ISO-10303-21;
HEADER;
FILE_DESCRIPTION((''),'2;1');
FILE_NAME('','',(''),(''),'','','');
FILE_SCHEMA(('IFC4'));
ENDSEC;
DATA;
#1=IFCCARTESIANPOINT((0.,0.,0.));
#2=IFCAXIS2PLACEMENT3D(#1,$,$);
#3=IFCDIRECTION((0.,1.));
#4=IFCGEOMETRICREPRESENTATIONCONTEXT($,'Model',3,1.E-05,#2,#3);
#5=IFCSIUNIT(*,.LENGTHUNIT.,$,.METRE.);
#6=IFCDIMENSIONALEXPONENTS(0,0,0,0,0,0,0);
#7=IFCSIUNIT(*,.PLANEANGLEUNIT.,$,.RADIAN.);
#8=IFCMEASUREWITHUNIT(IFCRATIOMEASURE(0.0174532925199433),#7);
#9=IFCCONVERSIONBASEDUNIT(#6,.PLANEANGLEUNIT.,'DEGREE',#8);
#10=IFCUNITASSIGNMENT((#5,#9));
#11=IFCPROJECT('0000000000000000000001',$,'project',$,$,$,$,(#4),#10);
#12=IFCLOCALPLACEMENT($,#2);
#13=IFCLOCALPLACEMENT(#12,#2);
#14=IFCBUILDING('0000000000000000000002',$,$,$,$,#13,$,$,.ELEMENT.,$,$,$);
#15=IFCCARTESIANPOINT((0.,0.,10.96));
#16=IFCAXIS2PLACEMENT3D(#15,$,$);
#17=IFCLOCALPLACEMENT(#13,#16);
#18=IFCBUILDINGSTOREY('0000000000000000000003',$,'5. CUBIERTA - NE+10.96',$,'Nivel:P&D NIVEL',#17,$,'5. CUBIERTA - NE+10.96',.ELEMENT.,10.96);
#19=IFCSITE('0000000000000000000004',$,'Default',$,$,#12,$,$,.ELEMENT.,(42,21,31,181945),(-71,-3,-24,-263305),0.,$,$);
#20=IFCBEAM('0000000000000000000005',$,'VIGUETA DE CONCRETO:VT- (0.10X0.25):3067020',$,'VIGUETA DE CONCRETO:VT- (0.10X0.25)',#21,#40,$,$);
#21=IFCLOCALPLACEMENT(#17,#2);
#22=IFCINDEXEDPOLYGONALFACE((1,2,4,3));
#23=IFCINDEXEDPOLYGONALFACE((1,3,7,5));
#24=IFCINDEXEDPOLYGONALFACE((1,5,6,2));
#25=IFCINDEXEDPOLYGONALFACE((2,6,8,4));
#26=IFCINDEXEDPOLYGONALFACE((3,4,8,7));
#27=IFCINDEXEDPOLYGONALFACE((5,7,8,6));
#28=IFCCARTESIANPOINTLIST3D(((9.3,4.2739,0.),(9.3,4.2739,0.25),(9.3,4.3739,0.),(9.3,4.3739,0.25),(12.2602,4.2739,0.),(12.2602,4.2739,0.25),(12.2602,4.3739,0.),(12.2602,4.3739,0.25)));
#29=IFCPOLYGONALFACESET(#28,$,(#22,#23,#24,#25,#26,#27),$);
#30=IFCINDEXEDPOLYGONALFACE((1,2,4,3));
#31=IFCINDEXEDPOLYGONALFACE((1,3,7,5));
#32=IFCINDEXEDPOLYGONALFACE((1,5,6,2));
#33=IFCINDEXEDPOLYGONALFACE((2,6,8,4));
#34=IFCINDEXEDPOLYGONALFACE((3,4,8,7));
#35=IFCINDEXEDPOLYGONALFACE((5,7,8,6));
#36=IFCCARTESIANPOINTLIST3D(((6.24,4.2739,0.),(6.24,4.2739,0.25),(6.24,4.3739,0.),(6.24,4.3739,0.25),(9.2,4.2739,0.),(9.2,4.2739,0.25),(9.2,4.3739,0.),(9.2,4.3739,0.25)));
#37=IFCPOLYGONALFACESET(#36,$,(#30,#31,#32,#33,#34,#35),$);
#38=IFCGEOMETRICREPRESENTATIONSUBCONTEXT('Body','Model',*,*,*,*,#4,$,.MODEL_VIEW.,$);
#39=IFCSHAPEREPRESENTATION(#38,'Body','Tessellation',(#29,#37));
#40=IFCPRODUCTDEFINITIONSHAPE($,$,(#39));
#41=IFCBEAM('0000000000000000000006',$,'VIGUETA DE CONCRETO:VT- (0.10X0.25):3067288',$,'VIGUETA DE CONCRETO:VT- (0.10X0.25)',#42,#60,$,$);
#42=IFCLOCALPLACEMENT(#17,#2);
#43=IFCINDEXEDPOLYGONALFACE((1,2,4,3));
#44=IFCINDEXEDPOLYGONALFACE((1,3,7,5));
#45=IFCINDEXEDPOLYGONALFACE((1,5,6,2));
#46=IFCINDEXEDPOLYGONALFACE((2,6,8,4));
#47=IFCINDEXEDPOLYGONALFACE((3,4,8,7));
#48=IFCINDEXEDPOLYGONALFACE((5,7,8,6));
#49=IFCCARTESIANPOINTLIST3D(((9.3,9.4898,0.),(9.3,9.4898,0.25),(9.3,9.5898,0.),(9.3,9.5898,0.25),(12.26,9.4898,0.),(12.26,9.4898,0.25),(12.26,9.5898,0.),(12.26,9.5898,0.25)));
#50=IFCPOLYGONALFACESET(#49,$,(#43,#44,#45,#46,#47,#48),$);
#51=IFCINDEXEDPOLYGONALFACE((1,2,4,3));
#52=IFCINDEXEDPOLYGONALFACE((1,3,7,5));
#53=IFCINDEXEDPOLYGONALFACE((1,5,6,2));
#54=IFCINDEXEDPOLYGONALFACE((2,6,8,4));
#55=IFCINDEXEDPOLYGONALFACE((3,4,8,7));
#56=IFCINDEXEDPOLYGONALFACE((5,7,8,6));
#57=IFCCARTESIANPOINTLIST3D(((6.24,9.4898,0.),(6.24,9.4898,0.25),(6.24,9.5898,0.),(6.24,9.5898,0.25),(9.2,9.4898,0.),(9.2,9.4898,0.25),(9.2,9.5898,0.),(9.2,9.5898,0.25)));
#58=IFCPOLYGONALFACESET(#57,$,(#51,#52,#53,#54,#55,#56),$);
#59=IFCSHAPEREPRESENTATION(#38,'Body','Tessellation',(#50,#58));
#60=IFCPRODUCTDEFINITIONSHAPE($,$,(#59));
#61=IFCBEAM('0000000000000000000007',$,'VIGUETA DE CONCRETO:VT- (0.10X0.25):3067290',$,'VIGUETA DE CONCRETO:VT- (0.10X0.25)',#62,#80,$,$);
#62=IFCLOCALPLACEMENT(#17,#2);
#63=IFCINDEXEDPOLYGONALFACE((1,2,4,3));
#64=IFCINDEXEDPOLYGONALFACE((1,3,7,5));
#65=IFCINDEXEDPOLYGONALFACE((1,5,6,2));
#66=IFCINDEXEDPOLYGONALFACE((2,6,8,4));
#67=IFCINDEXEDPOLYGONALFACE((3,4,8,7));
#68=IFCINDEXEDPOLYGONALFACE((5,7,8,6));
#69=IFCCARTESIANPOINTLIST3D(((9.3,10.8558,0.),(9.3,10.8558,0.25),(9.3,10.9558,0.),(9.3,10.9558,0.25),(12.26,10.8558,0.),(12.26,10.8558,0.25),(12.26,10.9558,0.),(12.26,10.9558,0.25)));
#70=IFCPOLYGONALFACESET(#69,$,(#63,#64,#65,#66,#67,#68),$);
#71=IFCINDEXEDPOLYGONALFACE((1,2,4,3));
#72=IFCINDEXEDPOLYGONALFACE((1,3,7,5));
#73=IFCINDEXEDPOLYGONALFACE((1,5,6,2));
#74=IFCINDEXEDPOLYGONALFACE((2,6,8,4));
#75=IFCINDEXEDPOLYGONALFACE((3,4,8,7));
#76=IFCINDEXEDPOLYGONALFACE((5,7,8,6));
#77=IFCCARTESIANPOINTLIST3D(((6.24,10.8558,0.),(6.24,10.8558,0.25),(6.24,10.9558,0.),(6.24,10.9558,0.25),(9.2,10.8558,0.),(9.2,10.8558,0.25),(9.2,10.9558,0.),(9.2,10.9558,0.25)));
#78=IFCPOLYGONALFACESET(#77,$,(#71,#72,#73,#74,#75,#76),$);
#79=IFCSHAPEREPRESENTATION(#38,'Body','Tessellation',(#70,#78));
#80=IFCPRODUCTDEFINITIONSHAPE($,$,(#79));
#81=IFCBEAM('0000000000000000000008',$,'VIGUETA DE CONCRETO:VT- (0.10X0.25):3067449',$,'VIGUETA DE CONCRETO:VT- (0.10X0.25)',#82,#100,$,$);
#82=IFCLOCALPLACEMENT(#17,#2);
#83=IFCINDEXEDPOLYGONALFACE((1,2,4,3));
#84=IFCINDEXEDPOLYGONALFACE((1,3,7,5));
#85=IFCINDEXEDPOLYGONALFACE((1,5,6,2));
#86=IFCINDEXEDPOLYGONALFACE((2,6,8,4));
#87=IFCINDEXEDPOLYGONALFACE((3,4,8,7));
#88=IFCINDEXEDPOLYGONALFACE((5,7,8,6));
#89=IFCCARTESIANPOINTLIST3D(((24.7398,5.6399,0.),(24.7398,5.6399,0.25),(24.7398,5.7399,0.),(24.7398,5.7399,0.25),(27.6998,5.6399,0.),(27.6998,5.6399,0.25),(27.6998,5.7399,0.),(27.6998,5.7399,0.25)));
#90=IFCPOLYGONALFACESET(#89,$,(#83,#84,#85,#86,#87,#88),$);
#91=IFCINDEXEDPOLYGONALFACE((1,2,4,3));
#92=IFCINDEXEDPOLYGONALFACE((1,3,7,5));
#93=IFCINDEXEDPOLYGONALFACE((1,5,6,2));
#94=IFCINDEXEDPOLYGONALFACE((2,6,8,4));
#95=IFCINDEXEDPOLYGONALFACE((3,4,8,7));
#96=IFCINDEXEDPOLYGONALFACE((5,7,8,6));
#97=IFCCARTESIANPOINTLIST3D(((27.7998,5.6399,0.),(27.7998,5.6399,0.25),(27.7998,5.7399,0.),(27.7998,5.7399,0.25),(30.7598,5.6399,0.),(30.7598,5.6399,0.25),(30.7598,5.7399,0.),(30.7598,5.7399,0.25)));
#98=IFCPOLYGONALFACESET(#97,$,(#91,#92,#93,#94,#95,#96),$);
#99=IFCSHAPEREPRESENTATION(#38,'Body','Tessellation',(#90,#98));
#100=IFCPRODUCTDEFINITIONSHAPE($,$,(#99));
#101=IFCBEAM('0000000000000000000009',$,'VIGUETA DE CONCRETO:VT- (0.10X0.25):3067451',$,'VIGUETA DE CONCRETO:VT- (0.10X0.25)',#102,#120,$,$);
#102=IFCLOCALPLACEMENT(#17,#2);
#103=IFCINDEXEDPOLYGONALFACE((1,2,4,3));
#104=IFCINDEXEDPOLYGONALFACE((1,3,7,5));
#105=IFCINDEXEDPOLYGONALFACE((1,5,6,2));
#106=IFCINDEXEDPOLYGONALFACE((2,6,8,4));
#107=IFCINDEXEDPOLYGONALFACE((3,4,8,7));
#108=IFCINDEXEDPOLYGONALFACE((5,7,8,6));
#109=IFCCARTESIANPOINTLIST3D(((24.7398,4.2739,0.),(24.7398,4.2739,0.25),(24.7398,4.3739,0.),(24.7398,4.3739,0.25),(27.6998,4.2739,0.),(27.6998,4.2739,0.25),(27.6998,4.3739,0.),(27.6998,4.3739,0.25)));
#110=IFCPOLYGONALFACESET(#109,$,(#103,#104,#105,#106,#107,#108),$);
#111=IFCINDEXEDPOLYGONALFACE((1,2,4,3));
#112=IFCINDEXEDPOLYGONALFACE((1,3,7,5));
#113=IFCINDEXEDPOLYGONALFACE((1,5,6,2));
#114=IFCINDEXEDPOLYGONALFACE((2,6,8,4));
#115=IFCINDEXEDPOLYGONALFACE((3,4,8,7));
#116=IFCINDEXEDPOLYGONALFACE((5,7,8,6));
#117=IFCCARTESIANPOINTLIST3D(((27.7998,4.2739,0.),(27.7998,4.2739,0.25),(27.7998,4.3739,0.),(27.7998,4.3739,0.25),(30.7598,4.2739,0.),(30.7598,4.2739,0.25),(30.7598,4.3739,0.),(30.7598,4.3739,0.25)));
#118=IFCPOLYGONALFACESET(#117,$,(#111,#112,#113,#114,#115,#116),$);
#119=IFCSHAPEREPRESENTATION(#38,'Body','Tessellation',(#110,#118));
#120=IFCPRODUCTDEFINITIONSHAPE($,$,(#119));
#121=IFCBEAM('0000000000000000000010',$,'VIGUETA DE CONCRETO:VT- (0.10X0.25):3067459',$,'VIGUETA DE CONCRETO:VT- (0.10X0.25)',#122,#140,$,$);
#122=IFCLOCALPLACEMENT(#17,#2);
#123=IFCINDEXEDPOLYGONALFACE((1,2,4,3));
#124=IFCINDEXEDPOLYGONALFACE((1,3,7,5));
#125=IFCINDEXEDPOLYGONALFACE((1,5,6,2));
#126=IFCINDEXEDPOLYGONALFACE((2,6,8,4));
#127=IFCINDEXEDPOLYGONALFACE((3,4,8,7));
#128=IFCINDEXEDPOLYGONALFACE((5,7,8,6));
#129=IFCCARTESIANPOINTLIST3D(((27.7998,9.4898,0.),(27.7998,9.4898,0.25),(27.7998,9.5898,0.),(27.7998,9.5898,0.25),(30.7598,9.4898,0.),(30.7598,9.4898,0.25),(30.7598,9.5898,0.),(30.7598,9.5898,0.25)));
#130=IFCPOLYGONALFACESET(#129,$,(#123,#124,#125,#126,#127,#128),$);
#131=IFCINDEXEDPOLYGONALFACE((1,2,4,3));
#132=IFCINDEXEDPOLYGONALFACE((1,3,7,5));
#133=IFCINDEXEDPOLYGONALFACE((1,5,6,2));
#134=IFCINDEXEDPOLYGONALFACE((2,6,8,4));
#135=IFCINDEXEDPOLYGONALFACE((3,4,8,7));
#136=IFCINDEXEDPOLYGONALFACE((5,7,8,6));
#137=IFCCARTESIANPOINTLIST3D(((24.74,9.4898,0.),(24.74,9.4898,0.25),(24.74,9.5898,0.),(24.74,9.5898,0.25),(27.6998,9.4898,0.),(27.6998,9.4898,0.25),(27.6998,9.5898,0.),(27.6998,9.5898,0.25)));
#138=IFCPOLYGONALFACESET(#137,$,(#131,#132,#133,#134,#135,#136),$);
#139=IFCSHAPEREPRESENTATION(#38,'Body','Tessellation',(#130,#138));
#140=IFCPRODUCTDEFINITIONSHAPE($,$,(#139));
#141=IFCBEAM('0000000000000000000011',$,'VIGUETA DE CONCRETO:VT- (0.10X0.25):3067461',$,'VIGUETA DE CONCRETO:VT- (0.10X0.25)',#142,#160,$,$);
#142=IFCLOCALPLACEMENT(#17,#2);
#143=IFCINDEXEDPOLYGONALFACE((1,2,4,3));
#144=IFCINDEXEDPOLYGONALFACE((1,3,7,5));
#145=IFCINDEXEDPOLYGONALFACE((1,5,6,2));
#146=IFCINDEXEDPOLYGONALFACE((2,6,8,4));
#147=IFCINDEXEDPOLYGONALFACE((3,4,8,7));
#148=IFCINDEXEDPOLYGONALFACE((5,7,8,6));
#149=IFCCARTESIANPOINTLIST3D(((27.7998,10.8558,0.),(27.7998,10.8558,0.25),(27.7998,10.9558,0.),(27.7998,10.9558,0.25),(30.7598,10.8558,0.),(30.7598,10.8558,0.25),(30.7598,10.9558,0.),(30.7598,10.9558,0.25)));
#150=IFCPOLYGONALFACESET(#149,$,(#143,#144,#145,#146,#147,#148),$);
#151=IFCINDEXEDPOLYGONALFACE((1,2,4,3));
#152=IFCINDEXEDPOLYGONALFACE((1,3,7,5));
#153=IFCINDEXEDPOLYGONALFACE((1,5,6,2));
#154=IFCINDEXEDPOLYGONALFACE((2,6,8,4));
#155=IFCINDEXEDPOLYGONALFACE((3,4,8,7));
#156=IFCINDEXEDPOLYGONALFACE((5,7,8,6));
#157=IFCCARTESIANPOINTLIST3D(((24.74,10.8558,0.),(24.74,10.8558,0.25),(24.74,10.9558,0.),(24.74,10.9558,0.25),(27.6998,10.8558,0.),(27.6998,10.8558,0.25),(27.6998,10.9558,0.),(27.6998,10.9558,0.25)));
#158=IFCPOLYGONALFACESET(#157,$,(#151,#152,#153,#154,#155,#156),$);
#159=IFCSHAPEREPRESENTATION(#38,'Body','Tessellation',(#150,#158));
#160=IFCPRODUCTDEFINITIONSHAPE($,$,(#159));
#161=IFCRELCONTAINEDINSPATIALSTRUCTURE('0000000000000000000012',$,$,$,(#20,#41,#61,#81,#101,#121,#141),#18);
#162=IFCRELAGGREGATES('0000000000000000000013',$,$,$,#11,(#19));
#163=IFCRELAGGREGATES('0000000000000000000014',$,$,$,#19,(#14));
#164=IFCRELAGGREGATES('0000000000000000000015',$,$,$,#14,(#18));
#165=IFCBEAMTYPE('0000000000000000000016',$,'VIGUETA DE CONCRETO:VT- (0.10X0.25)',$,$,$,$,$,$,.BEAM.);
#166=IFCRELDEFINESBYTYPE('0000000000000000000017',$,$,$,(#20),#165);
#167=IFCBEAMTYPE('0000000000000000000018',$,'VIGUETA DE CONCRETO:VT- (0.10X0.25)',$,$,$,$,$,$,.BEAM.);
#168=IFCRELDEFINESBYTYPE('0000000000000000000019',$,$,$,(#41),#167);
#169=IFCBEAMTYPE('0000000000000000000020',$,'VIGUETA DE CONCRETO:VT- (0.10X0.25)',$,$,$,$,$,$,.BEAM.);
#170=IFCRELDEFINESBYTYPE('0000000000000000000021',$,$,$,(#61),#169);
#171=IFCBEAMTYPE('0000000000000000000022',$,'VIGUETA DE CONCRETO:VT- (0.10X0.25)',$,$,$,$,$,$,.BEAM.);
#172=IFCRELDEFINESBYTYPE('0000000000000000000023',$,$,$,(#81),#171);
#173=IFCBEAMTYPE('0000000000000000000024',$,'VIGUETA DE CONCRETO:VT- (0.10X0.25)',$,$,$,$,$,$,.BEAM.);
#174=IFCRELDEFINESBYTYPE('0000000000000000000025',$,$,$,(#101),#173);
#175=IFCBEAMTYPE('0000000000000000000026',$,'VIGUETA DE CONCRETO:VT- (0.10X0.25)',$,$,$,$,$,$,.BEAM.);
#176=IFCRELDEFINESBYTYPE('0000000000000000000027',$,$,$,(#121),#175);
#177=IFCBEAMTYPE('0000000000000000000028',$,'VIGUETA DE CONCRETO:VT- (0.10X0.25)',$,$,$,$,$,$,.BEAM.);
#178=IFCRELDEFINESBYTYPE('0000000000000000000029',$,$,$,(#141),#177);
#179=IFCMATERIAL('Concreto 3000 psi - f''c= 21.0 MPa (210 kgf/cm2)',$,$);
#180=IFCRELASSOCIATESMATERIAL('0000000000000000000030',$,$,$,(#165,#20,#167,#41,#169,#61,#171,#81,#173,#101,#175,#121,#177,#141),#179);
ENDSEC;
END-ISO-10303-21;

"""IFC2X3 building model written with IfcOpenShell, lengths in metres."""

from ifc_helpers import new_model, entity, si_unit, converted_unit, direction, frame, frame_2d, origin, place, context, subcontext, project, spatial, rectangle, extrude, source, transform, mapped, material, type_object, type_shapes, element, save


model = new_model("IFC2X3")

# Units and contexts
model_context = context("Model", 3, precision=1e-05, world=origin(), true_north=direction((0.0, 1.0)))
body_context = subcontext(model_context, "Body", "Model", "MODEL_VIEW")
ifc_project = project(units=[si_unit("LENGTHUNIT", "METRE"), converted_unit("PLANEANGLEUNIT", "DEGREE", entity("IfcRatioMeasure", 0.0174532925199433), si_unit("PLANEANGLEUNIT", "RADIAN"), dimensions=[0, 0, 0, 0, 0, 0, 0])], contexts=[model_context])

# Site, building, storey
site_placement = place(None, origin())
site = spatial("IfcSite", under=ifc_project, at=site_placement, Name="Default", CompositionType="ELEMENT", RefLatitude=(42, 21, 31, 181945), RefLongitude=(-71, -3, -24, -263305), RefElevation=0.0)
building_placement = place(site_placement, origin())
building = spatial("IfcBuilding", under=site, at=building_placement, CompositionType="ELEMENT")
storey_placement = place(building_placement, frame((0.0, 0.0, 10.96)))
storey = spatial("IfcBuildingStorey", under=building, at=storey_placement, Name="5. CUBIERTA - NE+10.96", ObjectType="Nivel:P&D NIVEL", LongName="5. CUBIERTA - NE+10.96", CompositionType="ELEMENT", Elevation=10.96)

# Beams
ifc_material_1 = material(Name="Concreto 3000 psi - f'c= 21.0 MPa (210 kgf/cm2)")
beam_type_1 = type_object("IfcBeamType", Name="VIGUETA DE CONCRETO:VT- (0.10X0.25)", PredefinedType="BEAM", material=ifc_material_1)
shared_shape_1 = source(origin(), body_context, "Body", "SweptSolid", [
    extrude(rectangle(XDim=0.25, YDim=0.1, at=frame_2d((0.0, 0.0), x_axis=(1.0, 0.0))), frame((9.3, 4.3239, 11.085), z_axis=(1.0, 0.0, 0.0), x_axis=(0.0, 0.0, -1.0)), (0.0, 0.0, 1.0), 2.9602),
    extrude(rectangle(XDim=0.25, YDim=0.1, at=frame_2d((0.0, 0.0), x_axis=(1.0, 0.0))), frame((6.24, 4.3239, 11.085), z_axis=(1.0, 0.0, 0.0), x_axis=(0.0, 0.0, -1.0)), (0.0, 0.0, 1.0), 2.96),
])
type_shapes(beam_type_1, [shared_shape_1])
beam_1_placement = place(storey_placement, frame((0.0, 0.0, -10.96)))
element("IfcBeam", 1, at=beam_1_placement, inside=storey, type_object=beam_type_1, material=ifc_material_1, Name="VIGUETA DE CONCRETO:VT- (0.10X0.25):3067020", ObjectType="VIGUETA DE CONCRETO:VT- (0.10X0.25)", context=body_context, shape_type="MappedRepresentation", body=[
    mapped(shared_shape_1, transform((0.0, 0.0, 0.0), scale=1.0)),
])
beam_type_2 = type_object("IfcBeamType", Name="VIGUETA DE CONCRETO:VT- (0.10X0.25)", PredefinedType="BEAM", material=ifc_material_1)
shared_shape_2 = source(origin(), body_context, "Body", "SweptSolid", [
    extrude(rectangle(XDim=0.25, YDim=0.1, at=frame_2d((0.0, 0.0), x_axis=(1.0, 0.0))), frame((9.3, 9.5398, 11.085), z_axis=(1.0, 0.0, 0.0), x_axis=(0.0, 0.0, -1.0)), (0.0, 0.0, 1.0), 2.96),
    extrude(rectangle(XDim=0.25, YDim=0.1, at=frame_2d((0.0, 0.0), x_axis=(1.0, 0.0))), frame((6.24, 9.5398, 11.085), z_axis=(1.0, 0.0, 0.0), x_axis=(0.0, 0.0, -1.0)), (0.0, 0.0, 1.0), 2.96),
])
type_shapes(beam_type_2, [shared_shape_2])
beam_2_placement = place(storey_placement, frame((0.0, 0.0, -10.96)))
element("IfcBeam", 2, at=beam_2_placement, inside=storey, type_object=beam_type_2, material=ifc_material_1, Name="VIGUETA DE CONCRETO:VT- (0.10X0.25):3067288", ObjectType="VIGUETA DE CONCRETO:VT- (0.10X0.25)", context=body_context, shape_type="MappedRepresentation", body=[
    mapped(shared_shape_2, transform((0.0, 0.0, 0.0), scale=1.0)),
])
beam_type_3 = type_object("IfcBeamType", Name="VIGUETA DE CONCRETO:VT- (0.10X0.25)", PredefinedType="BEAM", material=ifc_material_1)
shared_shape_3 = source(origin(), body_context, "Body", "SweptSolid", [
    extrude(rectangle(XDim=0.25, YDim=0.1, at=frame_2d((0.0, 0.0), x_axis=(1.0, 0.0))), frame((9.3, 10.9058, 11.085), z_axis=(1.0, 0.0, 0.0), x_axis=(0.0, 0.0, -1.0)), (0.0, 0.0, 1.0), 2.96),
    extrude(rectangle(XDim=0.25, YDim=0.1, at=frame_2d((0.0, 0.0), x_axis=(1.0, 0.0))), frame((6.24, 10.9058, 11.085), z_axis=(1.0, 0.0, 0.0), x_axis=(0.0, 0.0, -1.0)), (0.0, 0.0, 1.0), 2.96),
])
type_shapes(beam_type_3, [shared_shape_3])
beam_3_placement = place(storey_placement, frame((0.0, 0.0, -10.96)))
element("IfcBeam", 3, at=beam_3_placement, inside=storey, type_object=beam_type_3, material=ifc_material_1, Name="VIGUETA DE CONCRETO:VT- (0.10X0.25):3067290", ObjectType="VIGUETA DE CONCRETO:VT- (0.10X0.25)", context=body_context, shape_type="MappedRepresentation", body=[
    mapped(shared_shape_3, transform((0.0, 0.0, 0.0), scale=1.0)),
])
beam_type_4 = type_object("IfcBeamType", Name="VIGUETA DE CONCRETO:VT- (0.10X0.25)", PredefinedType="BEAM", material=ifc_material_1)
shared_shape_4 = source(origin(), body_context, "Body", "SweptSolid", [
    extrude(rectangle(XDim=0.25, YDim=0.1, at=frame_2d((0.0, 0.0), x_axis=(1.0, 0.0))), frame((27.6998, 5.6899, 11.085), z_axis=(-1.0, 0.0, 0.0), x_axis=(0.0, 0.0, -1.0)), (0.0, 0.0, 1.0), 2.96),
    extrude(rectangle(XDim=0.25, YDim=0.1, at=frame_2d((0.0, 0.0), x_axis=(1.0, 0.0))), frame((30.7598, 5.6899, 11.085), z_axis=(-1.0, 0.0, 0.0), x_axis=(0.0, 0.0, -1.0)), (0.0, 0.0, 1.0), 2.96),
])
type_shapes(beam_type_4, [shared_shape_4])
beam_4_placement = place(storey_placement, frame((0.0, 0.0, -10.96)))
element("IfcBeam", 4, at=beam_4_placement, inside=storey, type_object=beam_type_4, material=ifc_material_1, Name="VIGUETA DE CONCRETO:VT- (0.10X0.25):3067449", ObjectType="VIGUETA DE CONCRETO:VT- (0.10X0.25)", context=body_context, shape_type="MappedRepresentation", body=[
    mapped(shared_shape_4, transform((0.0, 0.0, 0.0), scale=1.0)),
])
beam_type_5 = type_object("IfcBeamType", Name="VIGUETA DE CONCRETO:VT- (0.10X0.25)", PredefinedType="BEAM", material=ifc_material_1)
shared_shape_5 = source(origin(), body_context, "Body", "SweptSolid", [
    extrude(rectangle(XDim=0.25, YDim=0.1, at=frame_2d((0.0, 0.0), x_axis=(1.0, 0.0))), frame((27.6998, 4.3239, 11.085), z_axis=(-1.0, 0.0, 0.0), x_axis=(0.0, 0.0, -1.0)), (0.0, 0.0, 1.0), 2.96),
    extrude(rectangle(XDim=0.25, YDim=0.1, at=frame_2d((0.0, 0.0), x_axis=(1.0, 0.0))), frame((30.7598, 4.3239, 11.085), z_axis=(-1.0, 0.0, 0.0), x_axis=(0.0, 0.0, -1.0)), (0.0, 0.0, 1.0), 2.96),
])
type_shapes(beam_type_5, [shared_shape_5])
beam_5_placement = place(storey_placement, frame((0.0, 0.0, -10.96)))
element("IfcBeam", 5, at=beam_5_placement, inside=storey, type_object=beam_type_5, material=ifc_material_1, Name="VIGUETA DE CONCRETO:VT- (0.10X0.25):3067451", ObjectType="VIGUETA DE CONCRETO:VT- (0.10X0.25)", context=body_context, shape_type="MappedRepresentation", body=[
    mapped(shared_shape_5, transform((0.0, 0.0, 0.0), scale=1.0)),
])
beam_type_6 = type_object("IfcBeamType", Name="VIGUETA DE CONCRETO:VT- (0.10X0.25)", PredefinedType="BEAM", material=ifc_material_1)
shared_shape_6 = source(origin(), body_context, "Body", "SweptSolid", [
    extrude(rectangle(XDim=0.25, YDim=0.1, at=frame_2d((0.0, 0.0), x_axis=(1.0, 0.0))), frame((30.7598, 9.5398, 11.085), z_axis=(-1.0, 0.0, 0.0), x_axis=(0.0, 0.0, -1.0)), (0.0, 0.0, 1.0), 2.96),
    extrude(rectangle(XDim=0.25, YDim=0.1, at=frame_2d((0.0, 0.0), x_axis=(1.0, 0.0))), frame((27.6998, 9.5398, 11.085), z_axis=(-1.0, 0.0, 0.0), x_axis=(0.0, 0.0, -1.0)), (0.0, 0.0, 1.0), 2.9598),
])
type_shapes(beam_type_6, [shared_shape_6])
beam_6_placement = place(storey_placement, frame((0.0, 0.0, -10.96)))
element("IfcBeam", 6, at=beam_6_placement, inside=storey, type_object=beam_type_6, material=ifc_material_1, Name="VIGUETA DE CONCRETO:VT- (0.10X0.25):3067459", ObjectType="VIGUETA DE CONCRETO:VT- (0.10X0.25)", context=body_context, shape_type="MappedRepresentation", body=[
    mapped(shared_shape_6, transform((0.0, 0.0, 0.0), scale=1.0)),
])
beam_type_7 = type_object("IfcBeamType", Name="VIGUETA DE CONCRETO:VT- (0.10X0.25)", PredefinedType="BEAM", material=ifc_material_1)
shared_shape_7 = source(origin(), body_context, "Body", "SweptSolid", [
    extrude(rectangle(XDim=0.25, YDim=0.1, at=frame_2d((0.0, 0.0), x_axis=(1.0, 0.0))), frame((30.7598, 10.9058, 11.085), z_axis=(-1.0, 0.0, 0.0), x_axis=(0.0, 0.0, -1.0)), (0.0, 0.0, 1.0), 2.96),
    extrude(rectangle(XDim=0.25, YDim=0.1, at=frame_2d((0.0, 0.0), x_axis=(1.0, 0.0))), frame((27.6998, 10.9058, 11.085), z_axis=(-1.0, 0.0, 0.0), x_axis=(0.0, 0.0, -1.0)), (0.0, 0.0, 1.0), 2.9598),
])
type_shapes(beam_type_7, [shared_shape_7])
beam_7_placement = place(storey_placement, frame((0.0, 0.0, -10.96)))
element("IfcBeam", 7, at=beam_7_placement, inside=storey, type_object=beam_type_7, material=ifc_material_1, Name="VIGUETA DE CONCRETO:VT- (0.10X0.25):3067461", ObjectType="VIGUETA DE CONCRETO:VT- (0.10X0.25)", context=body_context, shape_type="MappedRepresentation", body=[
    mapped(shared_shape_7, transform((0.0, 0.0, 0.0), scale=1.0)),
])

save(model, "model.ifc")
